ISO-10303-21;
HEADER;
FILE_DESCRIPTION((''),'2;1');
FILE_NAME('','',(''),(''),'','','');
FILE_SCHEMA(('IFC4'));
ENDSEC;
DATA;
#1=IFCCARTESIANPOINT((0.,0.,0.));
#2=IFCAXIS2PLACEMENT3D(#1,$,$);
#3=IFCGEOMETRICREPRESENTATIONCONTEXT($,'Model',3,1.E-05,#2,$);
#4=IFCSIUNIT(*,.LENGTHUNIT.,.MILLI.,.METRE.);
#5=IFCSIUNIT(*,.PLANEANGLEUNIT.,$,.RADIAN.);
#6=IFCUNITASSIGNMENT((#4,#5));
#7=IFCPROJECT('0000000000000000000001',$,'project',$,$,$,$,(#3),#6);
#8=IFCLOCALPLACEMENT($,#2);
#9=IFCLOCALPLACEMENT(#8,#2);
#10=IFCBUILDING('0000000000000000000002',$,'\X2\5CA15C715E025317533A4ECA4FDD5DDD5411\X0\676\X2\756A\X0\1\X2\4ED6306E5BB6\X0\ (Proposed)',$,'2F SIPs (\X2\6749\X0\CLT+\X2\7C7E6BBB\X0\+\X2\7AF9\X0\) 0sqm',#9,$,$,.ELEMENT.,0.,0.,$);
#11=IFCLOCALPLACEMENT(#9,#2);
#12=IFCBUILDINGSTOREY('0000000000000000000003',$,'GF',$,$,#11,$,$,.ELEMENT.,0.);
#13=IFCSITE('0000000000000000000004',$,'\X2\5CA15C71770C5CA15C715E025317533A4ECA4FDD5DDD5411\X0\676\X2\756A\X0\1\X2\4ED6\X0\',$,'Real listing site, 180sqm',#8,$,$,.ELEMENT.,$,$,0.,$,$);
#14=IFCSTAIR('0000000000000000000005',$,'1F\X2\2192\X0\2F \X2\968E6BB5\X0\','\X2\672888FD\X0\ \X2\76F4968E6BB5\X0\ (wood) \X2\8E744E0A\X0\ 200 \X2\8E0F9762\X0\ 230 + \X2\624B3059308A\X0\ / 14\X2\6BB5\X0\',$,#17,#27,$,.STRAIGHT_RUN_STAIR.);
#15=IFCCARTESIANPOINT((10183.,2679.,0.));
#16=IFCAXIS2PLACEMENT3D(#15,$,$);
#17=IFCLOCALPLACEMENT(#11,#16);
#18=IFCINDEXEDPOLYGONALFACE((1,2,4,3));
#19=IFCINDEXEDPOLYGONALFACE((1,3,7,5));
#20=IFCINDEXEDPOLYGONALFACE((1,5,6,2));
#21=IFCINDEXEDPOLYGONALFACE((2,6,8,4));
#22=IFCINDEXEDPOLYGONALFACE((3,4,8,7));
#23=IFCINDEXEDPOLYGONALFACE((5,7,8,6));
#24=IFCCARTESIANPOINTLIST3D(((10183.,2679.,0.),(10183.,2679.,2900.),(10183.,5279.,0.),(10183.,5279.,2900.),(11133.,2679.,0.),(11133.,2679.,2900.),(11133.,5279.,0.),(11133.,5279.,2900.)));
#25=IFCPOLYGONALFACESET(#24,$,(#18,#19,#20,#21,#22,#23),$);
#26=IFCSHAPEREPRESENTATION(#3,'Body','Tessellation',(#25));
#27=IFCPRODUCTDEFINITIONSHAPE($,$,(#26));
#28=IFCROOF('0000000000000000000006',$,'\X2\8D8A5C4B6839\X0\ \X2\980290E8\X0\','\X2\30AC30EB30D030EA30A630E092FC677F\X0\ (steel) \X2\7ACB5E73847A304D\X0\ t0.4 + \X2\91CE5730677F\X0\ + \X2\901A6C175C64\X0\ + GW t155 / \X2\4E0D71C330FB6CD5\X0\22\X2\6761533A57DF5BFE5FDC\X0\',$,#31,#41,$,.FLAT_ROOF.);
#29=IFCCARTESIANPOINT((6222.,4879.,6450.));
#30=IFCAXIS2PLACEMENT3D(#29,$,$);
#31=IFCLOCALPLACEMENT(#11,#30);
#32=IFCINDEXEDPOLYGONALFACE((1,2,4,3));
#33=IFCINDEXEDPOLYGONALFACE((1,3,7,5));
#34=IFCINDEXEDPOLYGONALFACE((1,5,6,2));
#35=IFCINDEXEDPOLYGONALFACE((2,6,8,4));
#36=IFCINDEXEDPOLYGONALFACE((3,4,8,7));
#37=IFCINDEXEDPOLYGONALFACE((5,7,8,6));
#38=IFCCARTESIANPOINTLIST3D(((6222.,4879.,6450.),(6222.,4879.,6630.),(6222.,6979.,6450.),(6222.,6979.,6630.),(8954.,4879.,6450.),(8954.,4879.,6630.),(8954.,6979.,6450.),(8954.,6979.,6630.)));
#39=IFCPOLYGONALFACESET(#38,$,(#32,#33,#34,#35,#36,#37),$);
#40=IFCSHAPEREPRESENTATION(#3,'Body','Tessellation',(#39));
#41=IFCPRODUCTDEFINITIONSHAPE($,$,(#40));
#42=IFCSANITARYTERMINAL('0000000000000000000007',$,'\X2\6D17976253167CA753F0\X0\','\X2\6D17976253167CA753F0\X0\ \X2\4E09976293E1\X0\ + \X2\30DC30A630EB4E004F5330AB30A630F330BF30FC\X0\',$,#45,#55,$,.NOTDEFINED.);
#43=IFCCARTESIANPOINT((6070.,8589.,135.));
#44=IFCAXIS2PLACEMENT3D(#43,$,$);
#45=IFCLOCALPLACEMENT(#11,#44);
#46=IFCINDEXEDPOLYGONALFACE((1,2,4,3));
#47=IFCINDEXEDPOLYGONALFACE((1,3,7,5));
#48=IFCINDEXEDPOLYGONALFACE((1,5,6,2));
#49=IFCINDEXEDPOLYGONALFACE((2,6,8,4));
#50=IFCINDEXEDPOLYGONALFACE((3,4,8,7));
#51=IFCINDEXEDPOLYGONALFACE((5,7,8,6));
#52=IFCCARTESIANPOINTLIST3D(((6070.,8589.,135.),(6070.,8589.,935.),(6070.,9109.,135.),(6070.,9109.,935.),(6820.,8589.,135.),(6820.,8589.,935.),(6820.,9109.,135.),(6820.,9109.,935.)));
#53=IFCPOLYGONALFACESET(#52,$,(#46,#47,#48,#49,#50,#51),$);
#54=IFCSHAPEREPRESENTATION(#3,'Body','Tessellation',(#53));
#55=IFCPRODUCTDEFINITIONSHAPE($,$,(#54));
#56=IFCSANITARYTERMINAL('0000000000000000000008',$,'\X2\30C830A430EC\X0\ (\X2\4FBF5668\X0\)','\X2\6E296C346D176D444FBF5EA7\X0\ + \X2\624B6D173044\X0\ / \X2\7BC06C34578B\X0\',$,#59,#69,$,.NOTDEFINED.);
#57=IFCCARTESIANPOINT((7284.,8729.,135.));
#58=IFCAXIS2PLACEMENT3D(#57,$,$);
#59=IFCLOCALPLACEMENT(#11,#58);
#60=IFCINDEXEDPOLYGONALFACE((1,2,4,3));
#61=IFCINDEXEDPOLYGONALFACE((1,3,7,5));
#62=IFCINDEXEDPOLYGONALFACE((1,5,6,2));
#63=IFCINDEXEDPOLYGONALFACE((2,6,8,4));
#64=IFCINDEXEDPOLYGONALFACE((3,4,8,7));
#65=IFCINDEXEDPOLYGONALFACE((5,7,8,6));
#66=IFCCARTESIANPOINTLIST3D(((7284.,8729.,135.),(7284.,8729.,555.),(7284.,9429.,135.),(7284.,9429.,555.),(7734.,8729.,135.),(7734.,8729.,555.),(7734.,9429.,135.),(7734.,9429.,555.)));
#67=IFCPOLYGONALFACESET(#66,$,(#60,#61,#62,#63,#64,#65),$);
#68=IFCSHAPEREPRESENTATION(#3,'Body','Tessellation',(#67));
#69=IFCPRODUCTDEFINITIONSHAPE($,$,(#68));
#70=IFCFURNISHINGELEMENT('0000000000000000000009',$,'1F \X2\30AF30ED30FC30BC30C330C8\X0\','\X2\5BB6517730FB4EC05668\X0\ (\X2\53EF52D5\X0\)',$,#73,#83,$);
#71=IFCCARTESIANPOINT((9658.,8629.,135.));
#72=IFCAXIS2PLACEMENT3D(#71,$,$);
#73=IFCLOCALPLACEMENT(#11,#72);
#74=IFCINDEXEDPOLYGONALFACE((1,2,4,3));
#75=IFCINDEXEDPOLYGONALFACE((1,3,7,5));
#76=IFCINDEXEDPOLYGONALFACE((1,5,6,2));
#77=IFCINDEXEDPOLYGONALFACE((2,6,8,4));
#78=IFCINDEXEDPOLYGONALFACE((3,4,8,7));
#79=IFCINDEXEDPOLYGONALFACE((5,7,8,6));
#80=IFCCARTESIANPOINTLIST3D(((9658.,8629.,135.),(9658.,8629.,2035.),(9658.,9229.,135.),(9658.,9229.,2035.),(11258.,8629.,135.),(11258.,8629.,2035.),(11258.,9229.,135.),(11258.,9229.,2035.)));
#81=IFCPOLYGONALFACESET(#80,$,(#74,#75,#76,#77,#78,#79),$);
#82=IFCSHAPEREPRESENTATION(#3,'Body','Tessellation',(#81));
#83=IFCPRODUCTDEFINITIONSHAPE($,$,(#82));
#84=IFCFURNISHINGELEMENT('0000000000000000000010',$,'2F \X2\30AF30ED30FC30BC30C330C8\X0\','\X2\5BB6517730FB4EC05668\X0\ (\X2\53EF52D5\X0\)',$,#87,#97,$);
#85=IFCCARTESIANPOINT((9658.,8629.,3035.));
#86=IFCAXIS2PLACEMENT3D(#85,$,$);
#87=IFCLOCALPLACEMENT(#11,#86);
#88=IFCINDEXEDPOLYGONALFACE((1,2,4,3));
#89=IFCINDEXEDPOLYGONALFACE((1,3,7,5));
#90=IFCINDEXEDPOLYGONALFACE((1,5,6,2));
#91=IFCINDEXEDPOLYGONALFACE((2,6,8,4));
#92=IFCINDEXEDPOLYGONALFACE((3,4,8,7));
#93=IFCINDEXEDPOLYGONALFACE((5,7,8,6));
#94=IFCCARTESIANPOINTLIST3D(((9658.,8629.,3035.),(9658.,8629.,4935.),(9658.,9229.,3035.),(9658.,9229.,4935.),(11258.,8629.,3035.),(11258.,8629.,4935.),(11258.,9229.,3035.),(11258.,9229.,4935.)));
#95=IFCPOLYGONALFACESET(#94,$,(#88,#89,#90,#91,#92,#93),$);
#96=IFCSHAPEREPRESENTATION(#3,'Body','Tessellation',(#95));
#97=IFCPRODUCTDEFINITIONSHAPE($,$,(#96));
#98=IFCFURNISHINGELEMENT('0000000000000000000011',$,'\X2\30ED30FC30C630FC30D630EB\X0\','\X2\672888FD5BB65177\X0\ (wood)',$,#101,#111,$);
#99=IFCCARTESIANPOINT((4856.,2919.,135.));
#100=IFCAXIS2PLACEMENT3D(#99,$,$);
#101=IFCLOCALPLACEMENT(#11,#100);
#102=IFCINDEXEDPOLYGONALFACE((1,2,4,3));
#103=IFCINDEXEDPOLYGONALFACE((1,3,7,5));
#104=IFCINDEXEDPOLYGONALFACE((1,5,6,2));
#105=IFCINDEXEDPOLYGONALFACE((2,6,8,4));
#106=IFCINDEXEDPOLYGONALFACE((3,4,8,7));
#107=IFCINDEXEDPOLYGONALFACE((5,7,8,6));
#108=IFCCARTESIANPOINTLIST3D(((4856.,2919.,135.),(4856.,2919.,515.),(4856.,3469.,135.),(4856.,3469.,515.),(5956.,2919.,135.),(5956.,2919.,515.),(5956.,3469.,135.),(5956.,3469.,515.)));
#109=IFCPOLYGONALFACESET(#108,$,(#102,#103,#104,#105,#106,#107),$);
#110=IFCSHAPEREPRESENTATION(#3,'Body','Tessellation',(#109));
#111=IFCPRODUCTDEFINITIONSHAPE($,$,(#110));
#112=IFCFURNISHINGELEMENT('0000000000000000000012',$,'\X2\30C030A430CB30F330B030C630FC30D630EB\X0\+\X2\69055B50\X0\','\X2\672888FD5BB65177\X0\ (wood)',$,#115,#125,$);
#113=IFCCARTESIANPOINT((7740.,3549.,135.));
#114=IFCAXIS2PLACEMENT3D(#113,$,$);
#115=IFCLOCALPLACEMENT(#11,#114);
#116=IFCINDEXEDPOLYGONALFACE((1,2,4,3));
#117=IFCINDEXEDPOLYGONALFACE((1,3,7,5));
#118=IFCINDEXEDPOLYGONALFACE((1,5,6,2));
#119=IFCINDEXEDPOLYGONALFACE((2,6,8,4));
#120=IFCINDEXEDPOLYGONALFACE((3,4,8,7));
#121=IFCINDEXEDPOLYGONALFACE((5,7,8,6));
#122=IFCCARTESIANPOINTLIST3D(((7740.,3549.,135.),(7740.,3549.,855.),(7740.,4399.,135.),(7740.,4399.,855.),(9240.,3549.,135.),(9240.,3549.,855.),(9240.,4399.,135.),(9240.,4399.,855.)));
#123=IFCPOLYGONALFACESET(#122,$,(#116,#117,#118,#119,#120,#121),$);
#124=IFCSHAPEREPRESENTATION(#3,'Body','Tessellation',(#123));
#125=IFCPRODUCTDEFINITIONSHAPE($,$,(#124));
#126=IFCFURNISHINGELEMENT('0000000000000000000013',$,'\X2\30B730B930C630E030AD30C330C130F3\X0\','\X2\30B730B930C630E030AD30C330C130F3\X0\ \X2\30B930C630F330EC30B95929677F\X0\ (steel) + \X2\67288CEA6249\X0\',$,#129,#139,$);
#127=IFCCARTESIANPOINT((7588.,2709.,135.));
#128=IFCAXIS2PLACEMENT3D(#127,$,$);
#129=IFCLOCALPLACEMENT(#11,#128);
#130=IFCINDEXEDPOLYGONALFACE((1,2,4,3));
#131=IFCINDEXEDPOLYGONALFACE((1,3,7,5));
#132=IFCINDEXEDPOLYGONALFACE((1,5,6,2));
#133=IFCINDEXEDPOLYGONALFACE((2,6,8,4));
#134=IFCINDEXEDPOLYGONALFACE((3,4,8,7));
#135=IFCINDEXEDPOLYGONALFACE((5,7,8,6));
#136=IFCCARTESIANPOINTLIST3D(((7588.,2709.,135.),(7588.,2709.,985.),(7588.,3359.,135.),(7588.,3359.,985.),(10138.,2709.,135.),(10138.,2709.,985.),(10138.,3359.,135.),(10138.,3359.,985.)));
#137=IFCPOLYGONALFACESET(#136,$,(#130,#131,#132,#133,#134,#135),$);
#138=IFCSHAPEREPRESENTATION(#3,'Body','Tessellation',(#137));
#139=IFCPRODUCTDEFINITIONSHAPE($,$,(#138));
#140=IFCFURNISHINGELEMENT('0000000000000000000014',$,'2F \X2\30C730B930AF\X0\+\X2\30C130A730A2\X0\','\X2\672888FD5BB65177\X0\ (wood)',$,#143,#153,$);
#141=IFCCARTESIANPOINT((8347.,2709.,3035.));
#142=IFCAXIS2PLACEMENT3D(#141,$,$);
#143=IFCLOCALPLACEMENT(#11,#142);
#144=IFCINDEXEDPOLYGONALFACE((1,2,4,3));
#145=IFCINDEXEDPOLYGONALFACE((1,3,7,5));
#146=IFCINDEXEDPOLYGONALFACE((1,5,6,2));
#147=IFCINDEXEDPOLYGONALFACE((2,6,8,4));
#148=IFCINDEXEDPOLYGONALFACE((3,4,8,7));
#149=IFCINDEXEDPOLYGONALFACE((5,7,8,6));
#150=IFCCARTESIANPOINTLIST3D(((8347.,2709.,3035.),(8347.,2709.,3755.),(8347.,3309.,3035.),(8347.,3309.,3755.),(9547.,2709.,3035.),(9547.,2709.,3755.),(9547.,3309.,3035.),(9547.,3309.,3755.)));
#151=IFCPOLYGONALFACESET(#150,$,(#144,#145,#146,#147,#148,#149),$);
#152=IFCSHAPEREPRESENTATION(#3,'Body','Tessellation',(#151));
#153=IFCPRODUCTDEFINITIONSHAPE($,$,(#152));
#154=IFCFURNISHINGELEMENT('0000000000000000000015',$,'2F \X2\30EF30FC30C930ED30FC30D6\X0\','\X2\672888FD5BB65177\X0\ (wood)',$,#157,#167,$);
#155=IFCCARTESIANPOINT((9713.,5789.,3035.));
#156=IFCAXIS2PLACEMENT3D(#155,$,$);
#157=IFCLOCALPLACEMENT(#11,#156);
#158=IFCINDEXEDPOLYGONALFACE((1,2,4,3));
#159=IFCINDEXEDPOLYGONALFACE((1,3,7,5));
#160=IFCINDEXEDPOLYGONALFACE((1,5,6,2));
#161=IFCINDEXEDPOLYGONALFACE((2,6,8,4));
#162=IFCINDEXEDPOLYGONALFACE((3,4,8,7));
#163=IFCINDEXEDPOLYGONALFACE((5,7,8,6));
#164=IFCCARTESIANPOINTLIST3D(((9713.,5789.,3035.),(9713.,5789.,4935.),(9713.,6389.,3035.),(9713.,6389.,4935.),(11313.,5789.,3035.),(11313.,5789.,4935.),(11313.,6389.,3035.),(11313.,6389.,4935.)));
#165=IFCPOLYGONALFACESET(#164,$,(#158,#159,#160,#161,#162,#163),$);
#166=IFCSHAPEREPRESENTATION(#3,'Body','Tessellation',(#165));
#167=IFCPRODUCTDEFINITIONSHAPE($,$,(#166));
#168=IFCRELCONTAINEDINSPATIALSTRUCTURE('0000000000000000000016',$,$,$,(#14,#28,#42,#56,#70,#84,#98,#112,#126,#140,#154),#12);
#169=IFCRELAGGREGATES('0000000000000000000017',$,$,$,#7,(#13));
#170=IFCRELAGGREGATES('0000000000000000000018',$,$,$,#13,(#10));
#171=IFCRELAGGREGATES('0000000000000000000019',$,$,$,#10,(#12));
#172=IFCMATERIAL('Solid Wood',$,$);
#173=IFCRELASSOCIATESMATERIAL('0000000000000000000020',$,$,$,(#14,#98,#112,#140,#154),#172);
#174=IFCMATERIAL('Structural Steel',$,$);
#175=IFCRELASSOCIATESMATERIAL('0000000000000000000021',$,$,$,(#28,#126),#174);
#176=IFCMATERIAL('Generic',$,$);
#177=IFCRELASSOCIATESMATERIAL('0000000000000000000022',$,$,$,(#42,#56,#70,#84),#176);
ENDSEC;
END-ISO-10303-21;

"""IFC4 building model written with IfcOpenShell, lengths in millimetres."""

from ifc_helpers import new_model, si_unit, frame, frame_2d, origin, place, context, project, spatial, rectangle, extrude, material, element, save


model = new_model("IFC4")

# Units and contexts
model_context = context("Model", 3, precision=1e-05, world=origin())
ifc_project = project(units=[si_unit("LENGTHUNIT", "METRE", prefix="MILLI"), si_unit("PLANEANGLEUNIT", "RADIAN")], contexts=[model_context])

# Site, building, storey
site_placement = place(None, origin())
site = spatial("IfcSite", under=ifc_project, at=site_placement, Name="岡山県岡山市北区今保川向676番1他", ObjectType="Real listing site, 180sqm", CompositionType="ELEMENT", RefElevation=0.0)
building_placement = place(site_placement, origin())
building = spatial("IfcBuilding", under=site, at=building_placement, Name="岡山市北区今保川向676番1他の家 (Proposed)", ObjectType="2F SIPs (杉CLT+籾殻+竹) 0sqm", CompositionType="ELEMENT", ElevationOfRefHeight=0.0, ElevationOfTerrain=0.0)
storey_placement = place(building_placement, origin())
storey = spatial("IfcBuildingStorey", under=building, at=storey_placement, Name="GF", CompositionType="ELEMENT", Elevation=0.0)

# Shared definitions
ifc_material_1 = material(Name="Solid Wood")

# Stair
stair_placement = place(storey_placement, frame((10183.0, 2679.0, 0.0)))
element("IfcStair", 1, at=stair_placement, inside=storey, material=ifc_material_1, Name="1F→2F 階段", Description="木製 直階段 (wood) 蹴上 200 踏面 230 + 手すり / 14段", PredefinedType="STRAIGHT_RUN_STAIR", context=model_context, shape_type="SweptSolid", body=[
    extrude(rectangle(XDim=950.0, YDim=2600.0, at=frame_2d((475.0, 1300.0))), frame((10183.0, 2679.0, 0.0)), (0.0, 0.0, 1.0), 2900.0),
])

# Roof
ifc_material_2 = material(Name="Structural Steel")
roof_placement = place(storey_placement, frame((6222.0, 4879.0, 6450.0)))
element("IfcRoof", 2, at=roof_placement, inside=storey, material=ifc_material_2, Name="越屋根 頂部", Description="ガルバリウム鋼板 (steel) 立平葺き t0.4 + 野地板 + 通気層 + GW t155 / 不燃・法22条区域対応", PredefinedType="FLAT_ROOF", context=model_context, shape_type="SweptSolid", body=[
    extrude(rectangle(XDim=2732.0, YDim=2100.0, at=frame_2d((1366.0, 1050.0))), frame((6222.0, 4879.0, 6450.0)), (0.0, 0.0, 1.0), 180.0),
])

# Sanitary terminals
ifc_material_3 = material(Name="Generic")
sanitary_terminal_1_placement = place(storey_placement, frame((6070.0, 8589.0, 135.0)))
element("IfcSanitaryTerminal", 3, at=sanitary_terminal_1_placement, inside=storey, material=ifc_material_3, Name="洗面化粧台", Description="洗面化粧台 三面鏡 + ボウル一体カウンター", PredefinedType="NOTDEFINED", context=model_context, shape_type="SweptSolid", body=[
    extrude(rectangle(XDim=750.0, YDim=520.0, at=frame_2d((375.0, 260.0))), frame((6070.0, 8589.0, 135.0)), (0.0, 0.0, 1.0), 800.0),
])
sanitary_terminal_2_placement = place(storey_placement, frame((7284.0, 8729.0, 135.0)))
element("IfcSanitaryTerminal", 4, at=sanitary_terminal_2_placement, inside=storey, material=ifc_material_3, Name="トイレ (便器)", Description="温水洗浄便座 + 手洗い / 節水型", PredefinedType="NOTDEFINED", context=model_context, shape_type="SweptSolid", body=[
    extrude(rectangle(XDim=450.0, YDim=700.0, at=frame_2d((225.0, 350.0))), frame((7284.0, 8729.0, 135.0)), (0.0, 0.0, 1.0), 420.0),
])

# Furnishing elements
furnishing_1_placement = place(storey_placement, frame((9658.0, 8629.0, 135.0)))
element("IfcFurnishingElement", 5, at=furnishing_1_placement, inside=storey, material=ifc_material_3, Name="1F クローゼット", Description="家具・什器 (可動)", context=model_context, shape_type="SweptSolid", body=[
    extrude(rectangle(XDim=1600.0, YDim=600.0, at=frame_2d((800.0, 300.0))), frame((9658.0, 8629.0, 135.0)), (0.0, 0.0, 1.0), 1900.0),
])
furnishing_2_placement = place(storey_placement, frame((9658.0, 8629.0, 3035.0)))
element("IfcFurnishingElement", 6, at=furnishing_2_placement, inside=storey, material=ifc_material_3, Name="2F クローゼット", Description="家具・什器 (可動)", context=model_context, shape_type="SweptSolid", body=[
    extrude(rectangle(XDim=1600.0, YDim=600.0, at=frame_2d((800.0, 300.0))), frame((9658.0, 8629.0, 3035.0)), (0.0, 0.0, 1.0), 1900.0),
])
furnishing_3_placement = place(storey_placement, frame((4856.0, 2919.0, 135.0)))
element("IfcFurnishingElement", 7, at=furnishing_3_placement, inside=storey, material=ifc_material_1, Name="ローテーブル", Description="木製家具 (wood)", context=model_context, shape_type="SweptSolid", body=[
    extrude(rectangle(XDim=1100.0, YDim=550.0, at=frame_2d((550.0, 275.0))), frame((4856.0, 2919.0, 135.0)), (0.0, 0.0, 1.0), 380.0),
])
furnishing_4_placement = place(storey_placement, frame((7740.0, 3549.0, 135.0)))
element("IfcFurnishingElement", 8, at=furnishing_4_placement, inside=storey, material=ifc_material_1, Name="ダイニングテーブル+椅子", Description="木製家具 (wood)", context=model_context, shape_type="SweptSolid", body=[
    extrude(rectangle(XDim=1500.0, YDim=850.0, at=frame_2d((750.0, 425.0))), frame((7740.0, 3549.0, 135.0)), (0.0, 0.0, 1.0), 720.0),
])
furnishing_5_placement = place(storey_placement, frame((7588.0, 2709.0, 135.0)))
element("IfcFurnishingElement", 9, at=furnishing_5_placement, inside=storey, material=ifc_material_2, Name="システムキッチン", Description="システムキッチン ステンレス天板 (steel) + 木質扉", context=model_context, shape_type="SweptSolid", body=[
    extrude(rectangle(XDim=2550.0, YDim=650.0, at=frame_2d((1275.0, 325.0))), frame((7588.0, 2709.0, 135.0)), (0.0, 0.0, 1.0), 850.0),
])
furnishing_6_placement = place(storey_placement, frame((8347.0, 2709.0, 3035.0)))
element("IfcFurnishingElement", 10, at=furnishing_6_placement, inside=storey, material=ifc_material_1, Name="2F デスク+チェア", Description="木製家具 (wood)", context=model_context, shape_type="SweptSolid", body=[
    extrude(rectangle(XDim=1200.0, YDim=600.0, at=frame_2d((600.0, 300.0))), frame((8347.0, 2709.0, 3035.0)), (0.0, 0.0, 1.0), 720.0),
])
furnishing_7_placement = place(storey_placement, frame((9713.0, 5789.0, 3035.0)))
element("IfcFurnishingElement", 11, at=furnishing_7_placement, inside=storey, material=ifc_material_1, Name="2F ワードローブ", Description="木製家具 (wood)", context=model_context, shape_type="SweptSolid", body=[
    extrude(rectangle(XDim=1600.0, YDim=600.0, at=frame_2d((800.0, 300.0))), frame((9713.0, 5789.0, 3035.0)), (0.0, 0.0, 1.0), 1900.0),
])

save(model, "model.ifc")
